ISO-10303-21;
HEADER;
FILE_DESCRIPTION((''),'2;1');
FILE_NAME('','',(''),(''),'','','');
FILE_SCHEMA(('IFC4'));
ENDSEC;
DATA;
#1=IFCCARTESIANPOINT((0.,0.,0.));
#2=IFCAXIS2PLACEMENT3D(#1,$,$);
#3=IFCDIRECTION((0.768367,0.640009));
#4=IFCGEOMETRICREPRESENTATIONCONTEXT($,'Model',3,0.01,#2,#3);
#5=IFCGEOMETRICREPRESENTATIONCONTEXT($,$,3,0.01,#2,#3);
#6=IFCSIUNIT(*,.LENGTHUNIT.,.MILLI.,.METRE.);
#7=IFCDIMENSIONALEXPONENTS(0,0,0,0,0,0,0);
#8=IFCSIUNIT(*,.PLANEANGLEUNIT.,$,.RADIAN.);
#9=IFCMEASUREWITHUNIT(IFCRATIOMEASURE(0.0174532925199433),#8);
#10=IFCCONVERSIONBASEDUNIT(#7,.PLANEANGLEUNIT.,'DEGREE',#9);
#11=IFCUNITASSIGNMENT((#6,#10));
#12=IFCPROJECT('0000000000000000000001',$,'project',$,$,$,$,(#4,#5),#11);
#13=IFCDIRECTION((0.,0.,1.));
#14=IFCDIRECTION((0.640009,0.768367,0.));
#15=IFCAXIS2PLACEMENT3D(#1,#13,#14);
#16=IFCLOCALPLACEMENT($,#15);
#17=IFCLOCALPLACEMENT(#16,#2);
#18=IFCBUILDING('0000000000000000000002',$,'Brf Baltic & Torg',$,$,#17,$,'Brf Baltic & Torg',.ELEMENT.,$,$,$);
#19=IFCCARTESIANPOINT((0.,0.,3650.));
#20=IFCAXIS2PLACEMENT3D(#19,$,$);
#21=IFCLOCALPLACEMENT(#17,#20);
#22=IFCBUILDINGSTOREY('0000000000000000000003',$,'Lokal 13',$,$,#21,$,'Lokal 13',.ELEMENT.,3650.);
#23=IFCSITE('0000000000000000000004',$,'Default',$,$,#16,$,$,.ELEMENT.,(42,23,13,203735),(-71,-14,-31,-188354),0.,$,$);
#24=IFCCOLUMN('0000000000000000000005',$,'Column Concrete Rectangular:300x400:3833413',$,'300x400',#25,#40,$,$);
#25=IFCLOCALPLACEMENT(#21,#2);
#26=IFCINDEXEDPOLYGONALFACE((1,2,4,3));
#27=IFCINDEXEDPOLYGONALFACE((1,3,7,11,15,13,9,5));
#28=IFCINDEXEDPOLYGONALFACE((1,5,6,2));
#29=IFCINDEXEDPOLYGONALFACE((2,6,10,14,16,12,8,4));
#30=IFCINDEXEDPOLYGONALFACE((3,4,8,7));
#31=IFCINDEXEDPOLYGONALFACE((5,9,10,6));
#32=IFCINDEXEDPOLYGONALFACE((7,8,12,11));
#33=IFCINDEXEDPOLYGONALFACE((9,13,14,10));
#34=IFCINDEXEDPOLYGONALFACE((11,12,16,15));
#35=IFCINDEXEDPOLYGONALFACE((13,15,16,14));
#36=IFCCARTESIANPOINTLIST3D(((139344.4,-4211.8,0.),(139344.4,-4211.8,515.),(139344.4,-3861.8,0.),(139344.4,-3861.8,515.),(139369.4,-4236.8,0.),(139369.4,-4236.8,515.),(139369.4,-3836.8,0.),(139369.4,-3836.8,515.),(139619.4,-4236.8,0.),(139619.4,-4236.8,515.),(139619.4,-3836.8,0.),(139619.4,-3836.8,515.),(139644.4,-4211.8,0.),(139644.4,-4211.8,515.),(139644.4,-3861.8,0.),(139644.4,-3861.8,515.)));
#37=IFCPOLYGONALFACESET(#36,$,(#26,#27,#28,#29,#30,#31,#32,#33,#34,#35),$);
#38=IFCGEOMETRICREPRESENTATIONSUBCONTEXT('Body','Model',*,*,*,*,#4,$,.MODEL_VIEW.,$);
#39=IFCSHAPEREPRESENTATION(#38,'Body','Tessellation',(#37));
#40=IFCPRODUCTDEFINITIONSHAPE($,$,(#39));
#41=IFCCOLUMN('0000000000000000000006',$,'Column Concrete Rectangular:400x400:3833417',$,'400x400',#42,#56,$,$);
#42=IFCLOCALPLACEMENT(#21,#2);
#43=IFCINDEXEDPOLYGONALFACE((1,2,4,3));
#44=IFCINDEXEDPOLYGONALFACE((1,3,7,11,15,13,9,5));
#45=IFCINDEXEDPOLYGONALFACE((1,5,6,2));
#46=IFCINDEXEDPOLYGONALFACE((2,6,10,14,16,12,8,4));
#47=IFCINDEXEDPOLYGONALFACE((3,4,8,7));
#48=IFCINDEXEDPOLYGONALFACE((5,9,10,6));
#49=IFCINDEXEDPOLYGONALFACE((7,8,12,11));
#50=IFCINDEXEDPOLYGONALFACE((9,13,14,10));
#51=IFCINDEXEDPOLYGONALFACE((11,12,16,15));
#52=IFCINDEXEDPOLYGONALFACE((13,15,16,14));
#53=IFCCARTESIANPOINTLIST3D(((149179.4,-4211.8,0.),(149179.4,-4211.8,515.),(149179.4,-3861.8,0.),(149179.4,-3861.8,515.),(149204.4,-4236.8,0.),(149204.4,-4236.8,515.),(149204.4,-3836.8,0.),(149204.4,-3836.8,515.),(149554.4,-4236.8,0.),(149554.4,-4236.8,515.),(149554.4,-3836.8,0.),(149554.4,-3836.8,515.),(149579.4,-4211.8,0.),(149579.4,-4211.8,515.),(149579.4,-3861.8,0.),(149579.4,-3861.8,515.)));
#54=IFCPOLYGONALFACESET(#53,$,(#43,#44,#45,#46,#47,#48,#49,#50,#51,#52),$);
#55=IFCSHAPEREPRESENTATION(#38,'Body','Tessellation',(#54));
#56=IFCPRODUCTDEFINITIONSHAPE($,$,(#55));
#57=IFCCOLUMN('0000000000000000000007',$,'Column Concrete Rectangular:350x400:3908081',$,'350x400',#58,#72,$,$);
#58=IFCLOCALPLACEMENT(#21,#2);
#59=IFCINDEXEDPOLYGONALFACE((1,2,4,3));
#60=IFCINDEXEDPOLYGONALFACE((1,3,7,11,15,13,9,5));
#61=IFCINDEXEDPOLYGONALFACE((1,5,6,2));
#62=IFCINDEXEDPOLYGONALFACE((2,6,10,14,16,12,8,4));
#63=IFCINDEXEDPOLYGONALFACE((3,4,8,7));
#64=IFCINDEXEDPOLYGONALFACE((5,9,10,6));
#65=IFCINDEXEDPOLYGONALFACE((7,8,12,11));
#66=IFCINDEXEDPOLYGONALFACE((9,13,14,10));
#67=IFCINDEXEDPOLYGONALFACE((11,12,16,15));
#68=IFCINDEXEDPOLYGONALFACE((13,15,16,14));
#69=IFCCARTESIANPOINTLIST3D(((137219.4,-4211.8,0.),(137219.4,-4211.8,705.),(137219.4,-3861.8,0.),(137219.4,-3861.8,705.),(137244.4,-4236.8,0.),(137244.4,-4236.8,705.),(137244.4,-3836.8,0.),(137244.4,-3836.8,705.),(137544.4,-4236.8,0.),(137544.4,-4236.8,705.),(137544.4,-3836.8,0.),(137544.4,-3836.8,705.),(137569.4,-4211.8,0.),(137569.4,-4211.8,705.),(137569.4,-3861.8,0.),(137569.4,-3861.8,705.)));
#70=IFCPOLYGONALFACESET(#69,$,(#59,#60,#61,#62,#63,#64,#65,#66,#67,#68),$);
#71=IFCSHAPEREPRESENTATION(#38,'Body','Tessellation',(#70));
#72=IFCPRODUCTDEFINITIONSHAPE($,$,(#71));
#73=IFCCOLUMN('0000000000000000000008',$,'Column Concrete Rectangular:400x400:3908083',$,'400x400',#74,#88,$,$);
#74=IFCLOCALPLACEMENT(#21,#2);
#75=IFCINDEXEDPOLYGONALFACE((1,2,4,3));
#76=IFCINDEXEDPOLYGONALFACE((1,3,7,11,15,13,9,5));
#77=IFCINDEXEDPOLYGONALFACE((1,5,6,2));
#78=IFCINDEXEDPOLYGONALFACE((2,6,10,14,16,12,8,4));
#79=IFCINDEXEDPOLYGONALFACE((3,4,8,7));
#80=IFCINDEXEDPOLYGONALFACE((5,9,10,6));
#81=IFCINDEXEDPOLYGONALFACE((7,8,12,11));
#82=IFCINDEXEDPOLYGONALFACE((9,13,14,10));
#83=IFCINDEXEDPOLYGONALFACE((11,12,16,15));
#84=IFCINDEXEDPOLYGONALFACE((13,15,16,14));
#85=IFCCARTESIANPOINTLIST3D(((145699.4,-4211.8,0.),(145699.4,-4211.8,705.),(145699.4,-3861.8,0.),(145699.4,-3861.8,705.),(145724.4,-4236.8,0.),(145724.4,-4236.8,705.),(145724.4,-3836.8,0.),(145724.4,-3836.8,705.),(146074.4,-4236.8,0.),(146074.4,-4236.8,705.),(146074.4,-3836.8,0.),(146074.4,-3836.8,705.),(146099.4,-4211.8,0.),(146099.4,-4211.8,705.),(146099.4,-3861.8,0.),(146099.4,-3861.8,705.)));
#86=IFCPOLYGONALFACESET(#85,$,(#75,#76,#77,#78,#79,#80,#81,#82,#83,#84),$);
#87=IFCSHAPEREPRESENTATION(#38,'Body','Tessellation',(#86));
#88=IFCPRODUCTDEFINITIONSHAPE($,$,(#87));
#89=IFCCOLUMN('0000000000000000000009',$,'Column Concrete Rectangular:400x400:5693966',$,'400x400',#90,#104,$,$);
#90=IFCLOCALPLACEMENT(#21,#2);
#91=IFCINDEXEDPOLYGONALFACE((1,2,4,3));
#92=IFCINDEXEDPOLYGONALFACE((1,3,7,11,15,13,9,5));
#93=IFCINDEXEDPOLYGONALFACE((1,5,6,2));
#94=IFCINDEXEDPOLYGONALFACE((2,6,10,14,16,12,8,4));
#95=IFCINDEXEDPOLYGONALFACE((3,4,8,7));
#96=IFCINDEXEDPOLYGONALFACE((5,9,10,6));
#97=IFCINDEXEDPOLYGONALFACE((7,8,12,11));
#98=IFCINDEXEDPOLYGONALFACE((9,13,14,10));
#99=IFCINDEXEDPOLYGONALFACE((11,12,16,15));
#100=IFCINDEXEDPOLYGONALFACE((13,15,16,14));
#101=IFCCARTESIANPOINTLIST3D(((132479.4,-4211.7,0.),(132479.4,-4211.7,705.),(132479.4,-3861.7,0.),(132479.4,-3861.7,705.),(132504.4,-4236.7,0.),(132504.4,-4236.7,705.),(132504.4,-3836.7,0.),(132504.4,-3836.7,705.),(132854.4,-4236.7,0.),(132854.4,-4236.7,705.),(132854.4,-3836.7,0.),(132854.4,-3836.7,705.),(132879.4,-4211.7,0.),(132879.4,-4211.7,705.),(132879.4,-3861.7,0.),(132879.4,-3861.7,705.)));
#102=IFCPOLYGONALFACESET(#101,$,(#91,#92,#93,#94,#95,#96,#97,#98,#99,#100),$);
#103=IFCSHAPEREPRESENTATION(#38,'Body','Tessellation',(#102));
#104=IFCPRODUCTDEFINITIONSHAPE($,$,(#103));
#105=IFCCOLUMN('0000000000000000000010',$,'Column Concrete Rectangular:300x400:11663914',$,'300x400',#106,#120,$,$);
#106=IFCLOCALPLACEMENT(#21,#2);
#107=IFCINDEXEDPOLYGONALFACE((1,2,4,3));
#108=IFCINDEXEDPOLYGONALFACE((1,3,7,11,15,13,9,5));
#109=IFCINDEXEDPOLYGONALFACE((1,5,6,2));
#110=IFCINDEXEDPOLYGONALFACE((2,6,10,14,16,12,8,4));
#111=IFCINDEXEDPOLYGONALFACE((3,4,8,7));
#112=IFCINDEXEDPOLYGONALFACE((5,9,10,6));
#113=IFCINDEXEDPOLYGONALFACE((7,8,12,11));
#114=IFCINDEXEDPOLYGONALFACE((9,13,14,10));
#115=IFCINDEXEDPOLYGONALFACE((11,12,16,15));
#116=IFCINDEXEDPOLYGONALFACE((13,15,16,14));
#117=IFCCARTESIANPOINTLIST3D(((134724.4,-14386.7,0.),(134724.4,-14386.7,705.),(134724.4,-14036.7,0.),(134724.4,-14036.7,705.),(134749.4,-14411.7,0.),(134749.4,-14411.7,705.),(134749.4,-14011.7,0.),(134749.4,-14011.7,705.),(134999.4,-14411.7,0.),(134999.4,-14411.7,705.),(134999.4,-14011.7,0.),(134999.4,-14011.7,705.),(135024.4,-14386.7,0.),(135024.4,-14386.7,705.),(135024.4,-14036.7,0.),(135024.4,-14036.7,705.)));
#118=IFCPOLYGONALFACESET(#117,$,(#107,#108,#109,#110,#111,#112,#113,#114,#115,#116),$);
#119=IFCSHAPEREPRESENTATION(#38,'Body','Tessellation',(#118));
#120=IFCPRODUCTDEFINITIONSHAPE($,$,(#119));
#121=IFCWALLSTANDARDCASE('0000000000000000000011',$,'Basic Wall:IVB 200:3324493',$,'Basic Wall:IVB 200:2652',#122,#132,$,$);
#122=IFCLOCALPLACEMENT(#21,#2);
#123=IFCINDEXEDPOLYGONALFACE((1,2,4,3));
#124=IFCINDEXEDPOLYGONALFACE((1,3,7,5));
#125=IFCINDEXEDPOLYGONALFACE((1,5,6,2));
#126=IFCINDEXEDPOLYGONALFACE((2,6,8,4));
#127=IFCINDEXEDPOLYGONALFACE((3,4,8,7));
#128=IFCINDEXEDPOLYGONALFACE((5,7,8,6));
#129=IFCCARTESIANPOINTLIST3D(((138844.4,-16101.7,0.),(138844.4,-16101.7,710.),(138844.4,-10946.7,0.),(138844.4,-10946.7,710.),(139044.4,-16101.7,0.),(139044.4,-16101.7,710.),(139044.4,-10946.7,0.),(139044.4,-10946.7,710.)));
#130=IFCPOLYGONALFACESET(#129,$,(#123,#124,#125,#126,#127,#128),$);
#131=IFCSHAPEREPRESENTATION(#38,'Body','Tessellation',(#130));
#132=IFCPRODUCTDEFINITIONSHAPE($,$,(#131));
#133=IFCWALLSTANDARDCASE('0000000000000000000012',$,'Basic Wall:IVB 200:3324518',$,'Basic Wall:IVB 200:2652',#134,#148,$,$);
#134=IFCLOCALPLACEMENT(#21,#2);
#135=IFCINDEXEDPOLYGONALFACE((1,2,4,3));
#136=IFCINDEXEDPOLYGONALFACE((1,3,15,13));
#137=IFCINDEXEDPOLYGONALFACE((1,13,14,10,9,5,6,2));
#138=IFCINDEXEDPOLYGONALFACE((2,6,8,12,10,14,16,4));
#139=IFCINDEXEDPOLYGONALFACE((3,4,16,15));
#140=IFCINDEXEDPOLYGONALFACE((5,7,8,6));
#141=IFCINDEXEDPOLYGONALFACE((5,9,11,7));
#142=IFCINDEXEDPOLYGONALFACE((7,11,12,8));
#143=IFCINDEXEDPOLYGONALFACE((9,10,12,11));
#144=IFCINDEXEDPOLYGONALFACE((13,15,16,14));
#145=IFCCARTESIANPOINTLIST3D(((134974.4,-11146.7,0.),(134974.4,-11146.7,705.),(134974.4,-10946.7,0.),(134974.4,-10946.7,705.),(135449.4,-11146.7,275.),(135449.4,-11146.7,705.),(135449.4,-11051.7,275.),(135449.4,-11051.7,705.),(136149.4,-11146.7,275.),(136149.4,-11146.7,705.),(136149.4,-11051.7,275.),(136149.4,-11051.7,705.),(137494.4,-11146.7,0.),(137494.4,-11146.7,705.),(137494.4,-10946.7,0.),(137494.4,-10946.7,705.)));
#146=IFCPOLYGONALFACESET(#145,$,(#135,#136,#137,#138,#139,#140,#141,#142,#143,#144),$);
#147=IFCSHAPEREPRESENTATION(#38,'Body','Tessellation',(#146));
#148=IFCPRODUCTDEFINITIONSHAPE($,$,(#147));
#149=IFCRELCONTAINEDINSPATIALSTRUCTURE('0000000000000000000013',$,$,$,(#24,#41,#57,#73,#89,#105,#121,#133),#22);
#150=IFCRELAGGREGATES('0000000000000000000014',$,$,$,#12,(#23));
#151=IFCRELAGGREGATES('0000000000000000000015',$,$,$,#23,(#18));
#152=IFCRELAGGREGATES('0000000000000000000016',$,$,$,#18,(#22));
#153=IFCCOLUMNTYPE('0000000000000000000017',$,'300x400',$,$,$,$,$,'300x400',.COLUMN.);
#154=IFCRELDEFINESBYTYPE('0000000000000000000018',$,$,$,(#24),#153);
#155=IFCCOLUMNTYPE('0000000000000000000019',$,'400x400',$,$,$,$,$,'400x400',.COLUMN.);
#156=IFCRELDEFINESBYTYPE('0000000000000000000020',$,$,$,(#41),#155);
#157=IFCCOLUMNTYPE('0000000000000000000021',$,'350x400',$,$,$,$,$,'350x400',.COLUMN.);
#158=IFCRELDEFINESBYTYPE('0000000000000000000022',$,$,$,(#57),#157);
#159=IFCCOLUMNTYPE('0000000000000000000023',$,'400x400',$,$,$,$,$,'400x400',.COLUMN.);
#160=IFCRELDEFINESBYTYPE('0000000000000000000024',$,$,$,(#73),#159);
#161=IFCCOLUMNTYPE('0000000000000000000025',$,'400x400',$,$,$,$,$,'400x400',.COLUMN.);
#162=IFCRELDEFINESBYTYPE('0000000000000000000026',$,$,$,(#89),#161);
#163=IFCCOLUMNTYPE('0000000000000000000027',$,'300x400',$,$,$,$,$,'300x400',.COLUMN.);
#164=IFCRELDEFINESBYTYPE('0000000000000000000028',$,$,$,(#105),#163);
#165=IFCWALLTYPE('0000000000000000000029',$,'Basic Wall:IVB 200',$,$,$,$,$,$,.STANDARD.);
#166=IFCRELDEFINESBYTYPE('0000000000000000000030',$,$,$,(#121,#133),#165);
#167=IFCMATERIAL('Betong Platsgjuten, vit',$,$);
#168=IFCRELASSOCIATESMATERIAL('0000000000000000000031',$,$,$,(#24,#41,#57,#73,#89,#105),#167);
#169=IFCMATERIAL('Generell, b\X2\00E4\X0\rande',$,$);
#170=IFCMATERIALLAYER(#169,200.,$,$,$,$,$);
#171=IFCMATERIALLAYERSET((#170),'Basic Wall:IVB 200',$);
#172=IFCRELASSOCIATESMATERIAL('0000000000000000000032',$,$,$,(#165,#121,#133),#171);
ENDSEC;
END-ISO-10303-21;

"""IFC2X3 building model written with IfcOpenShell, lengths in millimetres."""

from ifc_helpers import new_model, entity, si_unit, converted_unit, direction, frame, frame_2d, origin, place, context, subcontext, project, spatial, polyline, rectangle, outline, extrude, clip, halfspace, source, transform, mapped, material, layer, layer_set, layer_usage, type_object, type_shapes, element, save


model = new_model("IFC2X3")

# Units and contexts
model_context = context("Model", 3, precision=0.01, world=origin(), true_north=direction((0.768367, 0.640009)))
context_of_model = context(None, 3, precision=0.01, world=origin(), true_north=direction((0.768367, 0.640009)))
body_context = subcontext(model_context, "Body", "Model", "MODEL_VIEW")
ifc_project = project(units=[si_unit("LENGTHUNIT", "METRE", prefix="MILLI"), converted_unit("PLANEANGLEUNIT", "DEGREE", entity("IfcRatioMeasure", 0.0174532925199433), si_unit("PLANEANGLEUNIT", "RADIAN"), dimensions=[0, 0, 0, 0, 0, 0, 0])], contexts=[model_context, context_of_model])

# Site, building, storey
site_placement = place(None, frame((0.0, 0.0, 0.0), z_axis=(0.0, 0.0, 1.0), x_axis=(0.640009, 0.768367, 0.0)))
site = spatial("IfcSite", under=ifc_project, at=site_placement, Name="Default", CompositionType="ELEMENT", RefLatitude=(42, 23, 13, 203735), RefLongitude=(-71, -14, -31, -188354), RefElevation=0.0)
building_placement = place(site_placement, origin())
building = spatial("IfcBuilding", under=site, at=building_placement, Name="Brf Baltic & Torg", LongName="Brf Baltic & Torg", CompositionType="ELEMENT")
storey_placement = place(building_placement, frame((0.0, 0.0, 3650.0)))
storey = spatial("IfcBuildingStorey", under=building, at=storey_placement, Name="Lokal 13", LongName="Lokal 13", CompositionType="ELEMENT", Elevation=3650.0)

# Columns
ifc_material_1 = material(Name="Betong Platsgjuten, vit")
column_type_1 = type_object("IfcColumnType", Name="300x400", ElementType="300x400", PredefinedType="COLUMN")
shared_shape_1 = source(origin(), body_context, "Body", "SweptSolid", [
    extrude(outline(polyline([(-175.0, -150.0), (175.0, -150.0), (200.0, -125.0), (200.0, 125.0), (175.0, 150.0), (-175.0, 150.0), (-200.0, 125.0), (-200.0, -125.0), (-175.0, -150.0)])), frame((0.0, 0.0, 3650.0), z_axis=(0.0, 0.0, 1.0), x_axis=(0.0, -1.0, 0.0)), (0.0, 0.0, 1.0), 515.0),
])
type_shapes(column_type_1, [shared_shape_1])
column_1_placement = place(storey_placement, frame((139494.4, -4036.8, -3650.0)))
element("IfcColumn", 1, at=column_1_placement, inside=storey, type_object=column_type_1, material=ifc_material_1, Name="Column Concrete Rectangular:300x400:3833413", ObjectType="300x400", context=body_context, shape_type="MappedRepresentation", body=[
    mapped(shared_shape_1, transform((0.0, 0.0, 0.0), scale=1.0)),
])
column_type_2 = type_object("IfcColumnType", Name="400x400", ElementType="400x400", PredefinedType="COLUMN")
shared_shape_2 = source(origin(), body_context, "Body", "SweptSolid", [
    extrude(outline(polyline([(-175.0, -200.0), (175.0, -200.0), (200.0, -175.0), (200.0, 175.0), (175.0, 200.0), (-175.0, 200.0), (-200.0, 175.0), (-200.0, -175.0), (-175.0, -200.0)])), frame((0.0, 0.0, 3650.0), z_axis=(0.0, 0.0, 1.0), x_axis=(0.0, -1.0, 0.0)), (0.0, 0.0, 1.0), 515.0),
])
type_shapes(column_type_2, [shared_shape_2])
column_2_placement = place(storey_placement, frame((149379.4, -4036.8, -3650.0)))
element("IfcColumn", 2, at=column_2_placement, inside=storey, type_object=column_type_2, material=ifc_material_1, Name="Column Concrete Rectangular:400x400:3833417", ObjectType="400x400", context=body_context, shape_type="MappedRepresentation", body=[
    mapped(shared_shape_2, transform((0.0, 0.0, 0.0), scale=1.0)),
])
column_type_3 = type_object("IfcColumnType", Name="350x400", ElementType="350x400", PredefinedType="COLUMN")
shared_shape_3 = source(origin(), body_context, "Body", "SweptSolid", [
    extrude(outline(polyline([(-175.0, -175.0), (175.0, -175.0), (200.0, -150.0), (200.0, 150.0), (175.0, 175.0), (-175.0, 175.0), (-200.0, 150.0), (-200.0, -150.0), (-175.0, -175.0)])), frame((0.0, 0.0, 3650.0), z_axis=(0.0, 0.0, 1.0), x_axis=(0.0, -1.0, 0.0)), (0.0, 0.0, 1.0), 705.0),
])
type_shapes(column_type_3, [shared_shape_3])
column_3_placement = place(storey_placement, frame((137394.4, -4036.8, -3650.0)))
element("IfcColumn", 3, at=column_3_placement, inside=storey, type_object=column_type_3, material=ifc_material_1, Name="Column Concrete Rectangular:350x400:3908081", ObjectType="350x400", context=body_context, shape_type="MappedRepresentation", body=[
    mapped(shared_shape_3, transform((0.0, 0.0, 0.0), scale=1.0)),
])
column_type_4 = type_object("IfcColumnType", Name="400x400", ElementType="400x400", PredefinedType="COLUMN")
shared_shape_4 = source(origin(), body_context, "Body", "SweptSolid", [
    extrude(outline(polyline([(-175.0, -200.0), (175.0, -200.0), (200.0, -175.0), (200.0, 175.0), (175.0, 200.0), (-175.0, 200.0), (-200.0, 175.0), (-200.0, -175.0), (-175.0, -200.0)])), frame((0.0, 0.0, 3650.0), z_axis=(0.0, 0.0, 1.0), x_axis=(0.0, -1.0, 0.0)), (0.0, 0.0, 1.0), 705.0),
])
type_shapes(column_type_4, [shared_shape_4])
column_4_placement = place(storey_placement, frame((145899.4, -4036.8, -3650.0)))
element("IfcColumn", 4, at=column_4_placement, inside=storey, type_object=column_type_4, material=ifc_material_1, Name="Column Concrete Rectangular:400x400:3908083", ObjectType="400x400", context=body_context, shape_type="MappedRepresentation", body=[
    mapped(shared_shape_4, transform((0.0, 0.0, 0.0), scale=1.0)),
])
column_type_5 = type_object("IfcColumnType", Name="400x400", ElementType="400x400", PredefinedType="COLUMN")
shared_shape_5 = source(origin(), body_context, "Body", "SweptSolid", [
    extrude(outline(polyline([(-175.0, -200.0), (175.0, -200.0), (200.0, -175.0), (200.0, 175.0), (175.0, 200.0), (-175.0, 200.0), (-200.0, 175.0), (-200.0, -175.0), (-175.0, -200.0)])), frame((0.0, 0.0, 3650.0), z_axis=(0.0, 0.0, 1.0), x_axis=(0.0, -1.0, 0.0)), (0.0, 0.0, 1.0), 705.0),
])
type_shapes(column_type_5, [shared_shape_5])
column_5_placement = place(storey_placement, frame((132679.4, -4036.7, -3650.0)))
element("IfcColumn", 5, at=column_5_placement, inside=storey, type_object=column_type_5, material=ifc_material_1, Name="Column Concrete Rectangular:400x400:5693966", ObjectType="400x400", context=body_context, shape_type="MappedRepresentation", body=[
    mapped(shared_shape_5, transform((0.0, 0.0, 0.0), scale=1.0)),
])
column_type_6 = type_object("IfcColumnType", Name="300x400", ElementType="300x400", PredefinedType="COLUMN")
shared_shape_6 = source(origin(), body_context, "Body", "SweptSolid", [
    extrude(outline(polyline([(-175.0, -150.0), (175.0, -150.0), (200.0, -125.0), (200.0, 125.0), (175.0, 150.0), (-175.0, 150.0), (-200.0, 125.0), (-200.0, -125.0), (-175.0, -150.0)])), frame((0.0, 0.0, 3650.0), z_axis=(0.0, 0.0, 1.0), x_axis=(0.0, -1.0, 0.0)), (0.0, 0.0, 1.0), 705.0),
])
type_shapes(column_type_6, [shared_shape_6])
column_6_placement = place(storey_placement, frame((134874.4, -14211.7, -3650.0)))
element("IfcColumn", 6, at=column_6_placement, inside=storey, type_object=column_type_6, material=ifc_material_1, Name="Column Concrete Rectangular:300x400:11663914", ObjectType="300x400", context=body_context, shape_type="MappedRepresentation", body=[
    mapped(shared_shape_6, transform((0.0, 0.0, 0.0), scale=1.0)),
])

# Shared definitions
ifc_material_2 = material(Name="Generell, bärande")
ifc_layer_1 = layer(ifc_material_2, 200.0)
ifc_layer_set_1 = layer_set([ifc_layer_1], Name="Basic Wall:IVB 200")
wall_type_1 = type_object("IfcWallType", Name="Basic Wall:IVB 200", PredefinedType="STANDARD", material=ifc_layer_set_1)

# Wall
ifc_layer_usage_1 = layer_usage(ifc_layer_set_1, "AXIS2", "NEGATIVE", 100.0)
wall_1_placement = place(storey_placement, frame((138944.4, -10946.7, 0.0), z_axis=(0.0, 0.0, 1.0), x_axis=(0.0, -1.0, 0.0)))
element("IfcWallStandardCase", 7, at=wall_1_placement, inside=storey, type_object=wall_type_1, material=ifc_layer_usage_1, Name="Basic Wall:IVB 200:3324493", ObjectType="Basic Wall:IVB 200:2652", context=body_context, shape_type="Clipping", body=[
    clip(extrude(rectangle(XDim=5155.0, YDim=200.0, at=frame_2d((2577.5, 0.0), x_axis=(-1.0, 0.0))), origin(), (0.0, 0.0, 1.0), 710.0), halfspace(frame((0.0, 0.0, -2000.0)), True)),
])

# Wall, opening
ifc_layer_usage_2 = layer_usage(ifc_layer_set_1, "AXIS2", "NEGATIVE", 100.0)
wall_2_placement = place(storey_placement, frame((134974.4, -11046.7, 0.0)))
wall_2 = element("IfcWallStandardCase", 8, at=wall_2_placement, inside=storey, type_object=wall_type_1, material=ifc_layer_usage_2, Name="Basic Wall:IVB 200:3324518", ObjectType="Basic Wall:IVB 200:2652", context=body_context, shape_type="Clipping", body=[
    clip(extrude(rectangle(XDim=2520.0, YDim=200.0, at=frame_2d((1260.0, 0.0), x_axis=(-1.0, 0.0))), origin(), (0.0, 0.0, 1.0), 705.0), halfspace(frame((0.0, 0.0, -2000.0)), True)),
])
opening_1_placement = place(wall_2_placement, origin())
element("IfcOpeningElement", 9, at=opening_1_placement, cuts=wall_2, ObjectType="Recess", context=body_context, shape_type="SweptSolid", body=[
    extrude(rectangle(XDim=430.0, YDim=700.0, at=frame_2d((0.0, 0.0), x_axis=(1.0, 0.0))), frame((825.0, -100.0, 490.0), z_axis=(0.0, 1.0, 0.0), x_axis=(0.0, 0.0, -1.0)), (0.0, 0.0, 1.0), 95.0),
])

save(model, "model.ifc")
